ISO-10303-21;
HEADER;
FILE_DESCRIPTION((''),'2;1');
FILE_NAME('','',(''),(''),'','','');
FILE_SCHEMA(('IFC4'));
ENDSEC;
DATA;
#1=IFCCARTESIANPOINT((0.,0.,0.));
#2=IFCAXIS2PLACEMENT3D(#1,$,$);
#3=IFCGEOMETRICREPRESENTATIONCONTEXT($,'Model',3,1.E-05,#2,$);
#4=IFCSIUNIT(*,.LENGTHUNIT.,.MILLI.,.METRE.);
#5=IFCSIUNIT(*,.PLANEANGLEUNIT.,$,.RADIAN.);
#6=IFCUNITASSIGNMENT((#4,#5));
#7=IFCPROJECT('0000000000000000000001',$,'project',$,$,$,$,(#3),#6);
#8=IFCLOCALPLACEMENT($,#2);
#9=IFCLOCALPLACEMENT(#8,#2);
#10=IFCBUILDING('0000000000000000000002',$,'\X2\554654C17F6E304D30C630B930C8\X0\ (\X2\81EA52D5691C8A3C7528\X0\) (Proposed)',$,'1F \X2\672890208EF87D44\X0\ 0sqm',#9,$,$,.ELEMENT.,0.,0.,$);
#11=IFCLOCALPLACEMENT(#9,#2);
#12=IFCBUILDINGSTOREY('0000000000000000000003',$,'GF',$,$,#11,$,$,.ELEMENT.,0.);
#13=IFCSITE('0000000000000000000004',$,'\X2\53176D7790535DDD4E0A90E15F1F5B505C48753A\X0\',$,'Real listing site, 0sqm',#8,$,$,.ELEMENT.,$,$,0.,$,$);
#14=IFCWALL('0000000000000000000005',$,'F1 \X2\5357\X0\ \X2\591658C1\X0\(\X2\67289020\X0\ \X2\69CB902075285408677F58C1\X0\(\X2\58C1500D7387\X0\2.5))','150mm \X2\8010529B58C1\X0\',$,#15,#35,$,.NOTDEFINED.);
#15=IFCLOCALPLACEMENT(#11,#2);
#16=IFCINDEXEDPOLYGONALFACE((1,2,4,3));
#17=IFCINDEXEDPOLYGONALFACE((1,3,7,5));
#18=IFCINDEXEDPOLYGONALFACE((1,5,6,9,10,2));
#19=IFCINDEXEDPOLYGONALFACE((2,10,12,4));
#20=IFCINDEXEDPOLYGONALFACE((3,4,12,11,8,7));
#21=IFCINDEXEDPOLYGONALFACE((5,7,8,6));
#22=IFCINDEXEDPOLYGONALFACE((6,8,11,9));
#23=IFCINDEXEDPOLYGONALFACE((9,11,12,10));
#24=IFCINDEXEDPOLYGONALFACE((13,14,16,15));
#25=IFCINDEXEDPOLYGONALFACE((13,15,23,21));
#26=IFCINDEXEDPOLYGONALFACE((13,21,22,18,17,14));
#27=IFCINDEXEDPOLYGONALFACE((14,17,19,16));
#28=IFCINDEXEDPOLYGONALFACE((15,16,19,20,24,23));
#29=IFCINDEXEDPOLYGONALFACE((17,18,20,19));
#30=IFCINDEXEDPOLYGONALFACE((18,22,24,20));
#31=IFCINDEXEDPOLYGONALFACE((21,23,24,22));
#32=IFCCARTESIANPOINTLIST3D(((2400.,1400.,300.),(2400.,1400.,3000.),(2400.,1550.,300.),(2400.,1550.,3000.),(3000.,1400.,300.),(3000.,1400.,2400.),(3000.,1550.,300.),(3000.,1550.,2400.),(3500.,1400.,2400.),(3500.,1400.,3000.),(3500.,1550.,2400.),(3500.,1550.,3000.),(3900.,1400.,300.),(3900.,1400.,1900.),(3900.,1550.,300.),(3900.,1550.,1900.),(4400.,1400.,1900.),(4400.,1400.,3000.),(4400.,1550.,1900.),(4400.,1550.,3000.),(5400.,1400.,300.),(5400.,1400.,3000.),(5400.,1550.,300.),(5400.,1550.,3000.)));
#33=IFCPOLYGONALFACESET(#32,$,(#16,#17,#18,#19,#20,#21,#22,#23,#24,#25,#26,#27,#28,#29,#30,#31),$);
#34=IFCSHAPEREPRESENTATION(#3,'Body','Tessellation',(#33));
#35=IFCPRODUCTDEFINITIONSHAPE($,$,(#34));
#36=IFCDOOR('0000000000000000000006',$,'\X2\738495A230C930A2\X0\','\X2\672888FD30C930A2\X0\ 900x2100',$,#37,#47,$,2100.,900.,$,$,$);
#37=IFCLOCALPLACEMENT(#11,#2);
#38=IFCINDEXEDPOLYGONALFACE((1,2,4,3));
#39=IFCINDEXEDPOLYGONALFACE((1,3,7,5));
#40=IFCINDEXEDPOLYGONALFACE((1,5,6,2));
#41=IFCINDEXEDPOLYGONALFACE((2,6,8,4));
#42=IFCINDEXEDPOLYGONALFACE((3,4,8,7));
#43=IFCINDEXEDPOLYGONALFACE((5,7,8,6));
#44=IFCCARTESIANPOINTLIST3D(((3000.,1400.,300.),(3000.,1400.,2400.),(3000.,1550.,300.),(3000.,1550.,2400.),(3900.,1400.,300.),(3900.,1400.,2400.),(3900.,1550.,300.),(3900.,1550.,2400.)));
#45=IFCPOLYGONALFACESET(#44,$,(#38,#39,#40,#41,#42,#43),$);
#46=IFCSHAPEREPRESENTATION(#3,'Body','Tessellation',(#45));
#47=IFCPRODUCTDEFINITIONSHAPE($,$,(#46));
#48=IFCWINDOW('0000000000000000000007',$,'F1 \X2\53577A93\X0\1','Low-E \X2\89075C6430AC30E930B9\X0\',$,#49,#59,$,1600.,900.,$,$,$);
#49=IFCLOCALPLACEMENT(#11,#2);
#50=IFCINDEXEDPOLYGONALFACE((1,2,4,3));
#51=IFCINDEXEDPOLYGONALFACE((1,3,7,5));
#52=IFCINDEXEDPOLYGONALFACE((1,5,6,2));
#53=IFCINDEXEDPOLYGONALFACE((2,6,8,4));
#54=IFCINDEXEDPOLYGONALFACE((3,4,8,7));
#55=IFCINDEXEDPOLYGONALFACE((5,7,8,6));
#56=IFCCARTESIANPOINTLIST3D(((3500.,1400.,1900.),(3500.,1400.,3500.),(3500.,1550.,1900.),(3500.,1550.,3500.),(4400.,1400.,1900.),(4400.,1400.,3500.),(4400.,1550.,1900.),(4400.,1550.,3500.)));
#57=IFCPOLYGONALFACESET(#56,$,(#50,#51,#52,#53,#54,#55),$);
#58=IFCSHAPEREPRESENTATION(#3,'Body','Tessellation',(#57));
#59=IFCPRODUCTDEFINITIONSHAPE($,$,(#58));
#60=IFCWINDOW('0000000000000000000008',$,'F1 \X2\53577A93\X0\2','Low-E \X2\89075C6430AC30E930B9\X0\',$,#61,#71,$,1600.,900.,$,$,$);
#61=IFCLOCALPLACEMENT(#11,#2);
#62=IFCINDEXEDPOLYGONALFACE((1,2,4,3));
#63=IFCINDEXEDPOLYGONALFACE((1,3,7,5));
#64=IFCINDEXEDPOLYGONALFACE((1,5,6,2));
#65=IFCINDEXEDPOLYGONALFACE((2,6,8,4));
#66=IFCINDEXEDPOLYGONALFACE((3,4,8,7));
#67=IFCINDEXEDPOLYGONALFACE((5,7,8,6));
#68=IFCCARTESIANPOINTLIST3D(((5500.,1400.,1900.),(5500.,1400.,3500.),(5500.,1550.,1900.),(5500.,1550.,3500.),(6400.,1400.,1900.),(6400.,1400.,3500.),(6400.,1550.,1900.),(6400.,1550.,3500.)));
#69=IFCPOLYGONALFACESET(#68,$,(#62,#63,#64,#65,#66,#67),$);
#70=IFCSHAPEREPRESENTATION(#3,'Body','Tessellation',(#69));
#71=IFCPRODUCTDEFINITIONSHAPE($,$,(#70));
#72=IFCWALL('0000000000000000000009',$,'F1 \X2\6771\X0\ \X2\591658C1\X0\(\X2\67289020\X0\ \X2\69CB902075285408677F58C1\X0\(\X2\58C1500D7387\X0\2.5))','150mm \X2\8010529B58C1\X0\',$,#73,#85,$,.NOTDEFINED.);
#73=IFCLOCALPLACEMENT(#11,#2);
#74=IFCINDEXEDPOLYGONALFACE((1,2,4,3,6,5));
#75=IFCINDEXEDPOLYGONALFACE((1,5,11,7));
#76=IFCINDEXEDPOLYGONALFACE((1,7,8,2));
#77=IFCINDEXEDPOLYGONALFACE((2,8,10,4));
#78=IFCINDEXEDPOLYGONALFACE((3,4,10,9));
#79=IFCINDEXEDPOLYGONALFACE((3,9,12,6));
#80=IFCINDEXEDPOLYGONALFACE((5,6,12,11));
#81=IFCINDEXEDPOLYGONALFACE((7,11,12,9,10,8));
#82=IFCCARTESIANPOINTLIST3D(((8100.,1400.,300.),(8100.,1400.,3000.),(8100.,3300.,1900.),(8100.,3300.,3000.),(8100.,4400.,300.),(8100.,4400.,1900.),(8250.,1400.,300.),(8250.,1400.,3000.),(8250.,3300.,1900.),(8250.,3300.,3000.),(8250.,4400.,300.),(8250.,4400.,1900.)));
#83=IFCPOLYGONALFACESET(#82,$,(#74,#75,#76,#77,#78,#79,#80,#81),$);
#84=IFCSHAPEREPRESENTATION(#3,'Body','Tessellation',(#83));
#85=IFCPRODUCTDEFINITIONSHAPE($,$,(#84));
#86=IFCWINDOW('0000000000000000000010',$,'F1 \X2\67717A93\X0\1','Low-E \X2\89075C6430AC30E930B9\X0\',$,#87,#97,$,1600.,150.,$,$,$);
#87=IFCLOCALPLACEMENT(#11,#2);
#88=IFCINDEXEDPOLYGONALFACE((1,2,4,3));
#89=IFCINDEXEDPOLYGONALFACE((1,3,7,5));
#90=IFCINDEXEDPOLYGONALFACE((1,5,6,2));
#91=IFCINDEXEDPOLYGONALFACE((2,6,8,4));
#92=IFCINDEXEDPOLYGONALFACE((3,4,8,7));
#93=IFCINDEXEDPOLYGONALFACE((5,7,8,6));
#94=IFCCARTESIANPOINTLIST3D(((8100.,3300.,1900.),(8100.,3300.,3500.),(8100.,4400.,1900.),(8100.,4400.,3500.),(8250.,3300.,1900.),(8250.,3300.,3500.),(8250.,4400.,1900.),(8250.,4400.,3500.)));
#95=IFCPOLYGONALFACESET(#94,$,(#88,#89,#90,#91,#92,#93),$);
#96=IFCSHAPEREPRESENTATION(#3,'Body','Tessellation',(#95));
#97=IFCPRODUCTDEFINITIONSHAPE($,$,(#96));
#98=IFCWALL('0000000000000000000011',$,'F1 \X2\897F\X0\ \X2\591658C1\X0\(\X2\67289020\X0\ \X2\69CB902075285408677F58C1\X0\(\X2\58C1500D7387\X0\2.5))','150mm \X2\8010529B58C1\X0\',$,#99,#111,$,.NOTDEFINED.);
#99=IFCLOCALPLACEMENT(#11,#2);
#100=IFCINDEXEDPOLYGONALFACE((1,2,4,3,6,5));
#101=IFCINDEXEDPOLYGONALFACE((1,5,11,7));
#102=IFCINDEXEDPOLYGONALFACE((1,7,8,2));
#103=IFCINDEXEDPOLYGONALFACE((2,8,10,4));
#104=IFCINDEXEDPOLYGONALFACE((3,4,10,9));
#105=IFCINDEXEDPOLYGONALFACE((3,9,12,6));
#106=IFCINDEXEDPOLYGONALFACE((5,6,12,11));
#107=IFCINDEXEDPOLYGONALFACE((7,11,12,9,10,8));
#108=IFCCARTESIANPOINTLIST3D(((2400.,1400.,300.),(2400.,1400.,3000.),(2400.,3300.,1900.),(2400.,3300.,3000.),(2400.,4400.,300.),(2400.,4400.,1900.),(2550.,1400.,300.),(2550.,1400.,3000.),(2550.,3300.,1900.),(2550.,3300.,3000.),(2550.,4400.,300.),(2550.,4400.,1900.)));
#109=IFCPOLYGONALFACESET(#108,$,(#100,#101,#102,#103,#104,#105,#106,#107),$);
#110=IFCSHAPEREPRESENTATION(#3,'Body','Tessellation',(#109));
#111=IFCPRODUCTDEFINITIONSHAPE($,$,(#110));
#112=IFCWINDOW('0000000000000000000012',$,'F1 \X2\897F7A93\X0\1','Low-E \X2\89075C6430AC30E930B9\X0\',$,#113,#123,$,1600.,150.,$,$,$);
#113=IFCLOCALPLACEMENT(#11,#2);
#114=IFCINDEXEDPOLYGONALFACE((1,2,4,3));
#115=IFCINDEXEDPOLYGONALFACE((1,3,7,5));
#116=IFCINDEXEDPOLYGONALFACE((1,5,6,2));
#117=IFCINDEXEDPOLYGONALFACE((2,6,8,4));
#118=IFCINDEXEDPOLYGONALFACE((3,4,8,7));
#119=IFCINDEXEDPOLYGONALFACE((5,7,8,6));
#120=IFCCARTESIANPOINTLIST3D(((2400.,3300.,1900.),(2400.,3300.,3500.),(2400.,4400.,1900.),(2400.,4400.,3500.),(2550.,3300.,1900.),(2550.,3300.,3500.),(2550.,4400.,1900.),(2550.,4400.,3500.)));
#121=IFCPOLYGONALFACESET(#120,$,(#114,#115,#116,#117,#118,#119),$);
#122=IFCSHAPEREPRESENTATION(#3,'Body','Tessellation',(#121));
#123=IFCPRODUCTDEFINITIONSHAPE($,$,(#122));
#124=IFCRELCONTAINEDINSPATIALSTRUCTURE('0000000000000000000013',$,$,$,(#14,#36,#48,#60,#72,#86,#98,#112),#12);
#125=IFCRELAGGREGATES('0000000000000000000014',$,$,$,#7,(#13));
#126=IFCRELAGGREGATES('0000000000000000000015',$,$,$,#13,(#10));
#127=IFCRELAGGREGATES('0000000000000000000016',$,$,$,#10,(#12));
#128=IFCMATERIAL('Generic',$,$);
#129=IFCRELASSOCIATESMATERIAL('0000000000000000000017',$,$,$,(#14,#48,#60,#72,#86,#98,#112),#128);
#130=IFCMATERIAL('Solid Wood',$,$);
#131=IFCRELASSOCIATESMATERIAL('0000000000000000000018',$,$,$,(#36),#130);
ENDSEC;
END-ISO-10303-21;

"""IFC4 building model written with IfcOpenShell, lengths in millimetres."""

from ifc_helpers import new_model, si_unit, frame, frame_2d, origin, place, context, project, spatial, rectangle, extrude, material, element, fill, save


model = new_model("IFC4")

# Units and contexts
model_context = context("Model", 3, precision=1e-05, world=origin())
ifc_project = project(units=[si_unit("LENGTHUNIT", "METRE", prefix="MILLI"), si_unit("PLANEANGLEUNIT", "RADIAN")], contexts=[model_context])

# Site, building, storey
site_placement = place(None, origin())
site = spatial("IfcSite", under=ifc_project, at=site_placement, Name="北海道川上郡弟子屈町", ObjectType="Real listing site, 0sqm", CompositionType="ELEMENT", RefElevation=0.0)
building_placement = place(site_placement, origin())
building = spatial("IfcBuilding", under=site, at=building_placement, Name="商品置きテスト (自動検証用) (Proposed)", ObjectType="1F 木造軸組 0sqm", CompositionType="ELEMENT", ElevationOfRefHeight=0.0, ElevationOfTerrain=0.0)
storey_placement = place(building_placement, origin())
storey = spatial("IfcBuildingStorey", under=building, at=storey_placement, Name="GF", CompositionType="ELEMENT", Elevation=0.0)

# Shared definitions
ifc_material_1 = material(Name="Generic")

# Wall, openings, door, windows
wall_1_placement = place(storey_placement, frame((1200.0, 700.0, 150.0)))
wall_1 = element("IfcWall", 1, at=wall_1_placement, inside=storey, material=ifc_material_1, Name="F1 南 外壁(木造 構造用合板壁(壁倍率2.5))", Description="150mm 耐力壁", PredefinedType="NOTDEFINED", context=model_context, shape_type="SweptSolid", body=[
    extrude(rectangle(XDim=3000.0, YDim=150.0, at=frame_2d((1500.0, 75.0))), frame((1200.0, 700.0, 150.0)), (0.0, 0.0, 1.0), 2700.0),
])
opening_1_placement = place(storey_placement, frame((1500.0, 700.0, 150.0)))
opening_1 = element("IfcOpeningElement", 2, at=opening_1_placement, cuts=wall_1, PredefinedType="NOTDEFINED", context=model_context, shape_type="SweptSolid", body=[
    extrude(rectangle(XDim=900.0, YDim=150.0, at=frame_2d((450.0, 75.0))), frame((1500.0, 700.0, 150.0)), (0.0, 0.0, 1.0), 2100.0),
])
opening_2_placement = place(storey_placement, frame((1750.0, 700.0, 950.0)))
opening_2 = element("IfcOpeningElement", 3, at=opening_2_placement, cuts=wall_1, PredefinedType="NOTDEFINED", context=model_context, shape_type="SweptSolid", body=[
    extrude(rectangle(XDim=900.0, YDim=150.0, at=frame_2d((450.0, 75.0))), frame((1750.0, 700.0, 950.0)), (0.0, 0.0, 1.0), 1600.0),
])
opening_3_placement = place(storey_placement, frame((2750.0, 700.0, 950.0)))
opening_3 = element("IfcOpeningElement", 4, at=opening_3_placement, cuts=wall_1, PredefinedType="NOTDEFINED", context=model_context, shape_type="SweptSolid", body=[
    extrude(rectangle(XDim=900.0, YDim=150.0, at=frame_2d((450.0, 75.0))), frame((2750.0, 700.0, 950.0)), (0.0, 0.0, 1.0), 1600.0),
])
ifc_material_2 = material(Name="Solid Wood")
door_placement = place(storey_placement, frame((1500.0, 700.0, 150.0)))
door = element("IfcDoor", 5, at=door_placement, inside=storey, material=ifc_material_2, Name="玄関ドア", Description="木製ドア 900x2100", OverallHeight=2100.0, OverallWidth=900.0, context=model_context, shape_type="SweptSolid", body=[
    extrude(rectangle(XDim=900.0, YDim=150.0, at=frame_2d((450.0, 75.0))), frame((1500.0, 700.0, 150.0)), (0.0, 0.0, 1.0), 2100.0),
])
fill(opening_1, door)
window_1_placement = place(storey_placement, frame((1750.0, 700.0, 950.0)))
window_1 = element("IfcWindow", 6, at=window_1_placement, inside=storey, material=ifc_material_1, Name="F1 南窓1", Description="Low-E 複層ガラス", OverallHeight=1600.0, OverallWidth=900.0, context=model_context, shape_type="SweptSolid", body=[
    extrude(rectangle(XDim=900.0, YDim=150.0, at=frame_2d((450.0, 75.0))), frame((1750.0, 700.0, 950.0)), (0.0, 0.0, 1.0), 1600.0),
])
fill(opening_2, window_1)
window_2_placement = place(storey_placement, frame((2750.0, 700.0, 950.0)))
window_2 = element("IfcWindow", 7, at=window_2_placement, inside=storey, material=ifc_material_1, Name="F1 南窓2", Description="Low-E 複層ガラス", OverallHeight=1600.0, OverallWidth=900.0, context=model_context, shape_type="SweptSolid", body=[
    extrude(rectangle(XDim=900.0, YDim=150.0, at=frame_2d((450.0, 75.0))), frame((2750.0, 700.0, 950.0)), (0.0, 0.0, 1.0), 1600.0),
])
fill(opening_3, window_2)

# Walls, openings, windows
wall_2_placement = place(storey_placement, frame((4050.0, 700.0, 150.0)))
wall_2 = element("IfcWall", 8, at=wall_2_placement, inside=storey, material=ifc_material_1, Name="F1 東 外壁(木造 構造用合板壁(壁倍率2.5))", Description="150mm 耐力壁", PredefinedType="NOTDEFINED", context=model_context, shape_type="SweptSolid", body=[
    extrude(rectangle(XDim=150.0, YDim=3000.0, at=frame_2d((75.0, 1500.0))), frame((4050.0, 700.0, 150.0)), (0.0, 0.0, 1.0), 2700.0),
])
opening_4_placement = place(storey_placement, frame((4050.0, 1650.0, 950.0)))
opening_4 = element("IfcOpeningElement", 9, at=opening_4_placement, cuts=wall_2, PredefinedType="NOTDEFINED", context=model_context, shape_type="SweptSolid", body=[
    extrude(rectangle(XDim=150.0, YDim=1100.0, at=frame_2d((75.0, 550.0))), frame((4050.0, 1650.0, 950.0)), (0.0, 0.0, 1.0), 1600.0),
])
window_3_placement = place(storey_placement, frame((4050.0, 1650.0, 950.0)))
window_3 = element("IfcWindow", 10, at=window_3_placement, inside=storey, material=ifc_material_1, Name="F1 東窓1", Description="Low-E 複層ガラス", OverallHeight=1600.0, OverallWidth=150.0, context=model_context, shape_type="SweptSolid", body=[
    extrude(rectangle(XDim=150.0, YDim=1100.0, at=frame_2d((75.0, 550.0))), frame((4050.0, 1650.0, 950.0)), (0.0, 0.0, 1.0), 1600.0),
])
fill(opening_4, window_3)
wall_3_placement = place(storey_placement, frame((1200.0, 700.0, 150.0)))
wall_3 = element("IfcWall", 11, at=wall_3_placement, inside=storey, material=ifc_material_1, Name="F1 西 外壁(木造 構造用合板壁(壁倍率2.5))", Description="150mm 耐力壁", PredefinedType="NOTDEFINED", context=model_context, shape_type="SweptSolid", body=[
    extrude(rectangle(XDim=150.0, YDim=3000.0, at=frame_2d((75.0, 1500.0))), frame((1200.0, 700.0, 150.0)), (0.0, 0.0, 1.0), 2700.0),
])
opening_5_placement = place(storey_placement, frame((1200.0, 1650.0, 950.0)))
opening_5 = element("IfcOpeningElement", 12, at=opening_5_placement, cuts=wall_3, PredefinedType="NOTDEFINED", context=model_context, shape_type="SweptSolid", body=[
    extrude(rectangle(XDim=150.0, YDim=1100.0, at=frame_2d((75.0, 550.0))), frame((1200.0, 1650.0, 950.0)), (0.0, 0.0, 1.0), 1600.0),
])
window_4_placement = place(storey_placement, frame((1200.0, 1650.0, 950.0)))
window_4 = element("IfcWindow", 13, at=window_4_placement, inside=storey, material=ifc_material_1, Name="F1 西窓1", Description="Low-E 複層ガラス", OverallHeight=1600.0, OverallWidth=150.0, context=model_context, shape_type="SweptSolid", body=[
    extrude(rectangle(XDim=150.0, YDim=1100.0, at=frame_2d((75.0, 550.0))), frame((1200.0, 1650.0, 950.0)), (0.0, 0.0, 1.0), 1600.0),
])
fill(opening_5, window_4)

save(model, "model.ifc")
